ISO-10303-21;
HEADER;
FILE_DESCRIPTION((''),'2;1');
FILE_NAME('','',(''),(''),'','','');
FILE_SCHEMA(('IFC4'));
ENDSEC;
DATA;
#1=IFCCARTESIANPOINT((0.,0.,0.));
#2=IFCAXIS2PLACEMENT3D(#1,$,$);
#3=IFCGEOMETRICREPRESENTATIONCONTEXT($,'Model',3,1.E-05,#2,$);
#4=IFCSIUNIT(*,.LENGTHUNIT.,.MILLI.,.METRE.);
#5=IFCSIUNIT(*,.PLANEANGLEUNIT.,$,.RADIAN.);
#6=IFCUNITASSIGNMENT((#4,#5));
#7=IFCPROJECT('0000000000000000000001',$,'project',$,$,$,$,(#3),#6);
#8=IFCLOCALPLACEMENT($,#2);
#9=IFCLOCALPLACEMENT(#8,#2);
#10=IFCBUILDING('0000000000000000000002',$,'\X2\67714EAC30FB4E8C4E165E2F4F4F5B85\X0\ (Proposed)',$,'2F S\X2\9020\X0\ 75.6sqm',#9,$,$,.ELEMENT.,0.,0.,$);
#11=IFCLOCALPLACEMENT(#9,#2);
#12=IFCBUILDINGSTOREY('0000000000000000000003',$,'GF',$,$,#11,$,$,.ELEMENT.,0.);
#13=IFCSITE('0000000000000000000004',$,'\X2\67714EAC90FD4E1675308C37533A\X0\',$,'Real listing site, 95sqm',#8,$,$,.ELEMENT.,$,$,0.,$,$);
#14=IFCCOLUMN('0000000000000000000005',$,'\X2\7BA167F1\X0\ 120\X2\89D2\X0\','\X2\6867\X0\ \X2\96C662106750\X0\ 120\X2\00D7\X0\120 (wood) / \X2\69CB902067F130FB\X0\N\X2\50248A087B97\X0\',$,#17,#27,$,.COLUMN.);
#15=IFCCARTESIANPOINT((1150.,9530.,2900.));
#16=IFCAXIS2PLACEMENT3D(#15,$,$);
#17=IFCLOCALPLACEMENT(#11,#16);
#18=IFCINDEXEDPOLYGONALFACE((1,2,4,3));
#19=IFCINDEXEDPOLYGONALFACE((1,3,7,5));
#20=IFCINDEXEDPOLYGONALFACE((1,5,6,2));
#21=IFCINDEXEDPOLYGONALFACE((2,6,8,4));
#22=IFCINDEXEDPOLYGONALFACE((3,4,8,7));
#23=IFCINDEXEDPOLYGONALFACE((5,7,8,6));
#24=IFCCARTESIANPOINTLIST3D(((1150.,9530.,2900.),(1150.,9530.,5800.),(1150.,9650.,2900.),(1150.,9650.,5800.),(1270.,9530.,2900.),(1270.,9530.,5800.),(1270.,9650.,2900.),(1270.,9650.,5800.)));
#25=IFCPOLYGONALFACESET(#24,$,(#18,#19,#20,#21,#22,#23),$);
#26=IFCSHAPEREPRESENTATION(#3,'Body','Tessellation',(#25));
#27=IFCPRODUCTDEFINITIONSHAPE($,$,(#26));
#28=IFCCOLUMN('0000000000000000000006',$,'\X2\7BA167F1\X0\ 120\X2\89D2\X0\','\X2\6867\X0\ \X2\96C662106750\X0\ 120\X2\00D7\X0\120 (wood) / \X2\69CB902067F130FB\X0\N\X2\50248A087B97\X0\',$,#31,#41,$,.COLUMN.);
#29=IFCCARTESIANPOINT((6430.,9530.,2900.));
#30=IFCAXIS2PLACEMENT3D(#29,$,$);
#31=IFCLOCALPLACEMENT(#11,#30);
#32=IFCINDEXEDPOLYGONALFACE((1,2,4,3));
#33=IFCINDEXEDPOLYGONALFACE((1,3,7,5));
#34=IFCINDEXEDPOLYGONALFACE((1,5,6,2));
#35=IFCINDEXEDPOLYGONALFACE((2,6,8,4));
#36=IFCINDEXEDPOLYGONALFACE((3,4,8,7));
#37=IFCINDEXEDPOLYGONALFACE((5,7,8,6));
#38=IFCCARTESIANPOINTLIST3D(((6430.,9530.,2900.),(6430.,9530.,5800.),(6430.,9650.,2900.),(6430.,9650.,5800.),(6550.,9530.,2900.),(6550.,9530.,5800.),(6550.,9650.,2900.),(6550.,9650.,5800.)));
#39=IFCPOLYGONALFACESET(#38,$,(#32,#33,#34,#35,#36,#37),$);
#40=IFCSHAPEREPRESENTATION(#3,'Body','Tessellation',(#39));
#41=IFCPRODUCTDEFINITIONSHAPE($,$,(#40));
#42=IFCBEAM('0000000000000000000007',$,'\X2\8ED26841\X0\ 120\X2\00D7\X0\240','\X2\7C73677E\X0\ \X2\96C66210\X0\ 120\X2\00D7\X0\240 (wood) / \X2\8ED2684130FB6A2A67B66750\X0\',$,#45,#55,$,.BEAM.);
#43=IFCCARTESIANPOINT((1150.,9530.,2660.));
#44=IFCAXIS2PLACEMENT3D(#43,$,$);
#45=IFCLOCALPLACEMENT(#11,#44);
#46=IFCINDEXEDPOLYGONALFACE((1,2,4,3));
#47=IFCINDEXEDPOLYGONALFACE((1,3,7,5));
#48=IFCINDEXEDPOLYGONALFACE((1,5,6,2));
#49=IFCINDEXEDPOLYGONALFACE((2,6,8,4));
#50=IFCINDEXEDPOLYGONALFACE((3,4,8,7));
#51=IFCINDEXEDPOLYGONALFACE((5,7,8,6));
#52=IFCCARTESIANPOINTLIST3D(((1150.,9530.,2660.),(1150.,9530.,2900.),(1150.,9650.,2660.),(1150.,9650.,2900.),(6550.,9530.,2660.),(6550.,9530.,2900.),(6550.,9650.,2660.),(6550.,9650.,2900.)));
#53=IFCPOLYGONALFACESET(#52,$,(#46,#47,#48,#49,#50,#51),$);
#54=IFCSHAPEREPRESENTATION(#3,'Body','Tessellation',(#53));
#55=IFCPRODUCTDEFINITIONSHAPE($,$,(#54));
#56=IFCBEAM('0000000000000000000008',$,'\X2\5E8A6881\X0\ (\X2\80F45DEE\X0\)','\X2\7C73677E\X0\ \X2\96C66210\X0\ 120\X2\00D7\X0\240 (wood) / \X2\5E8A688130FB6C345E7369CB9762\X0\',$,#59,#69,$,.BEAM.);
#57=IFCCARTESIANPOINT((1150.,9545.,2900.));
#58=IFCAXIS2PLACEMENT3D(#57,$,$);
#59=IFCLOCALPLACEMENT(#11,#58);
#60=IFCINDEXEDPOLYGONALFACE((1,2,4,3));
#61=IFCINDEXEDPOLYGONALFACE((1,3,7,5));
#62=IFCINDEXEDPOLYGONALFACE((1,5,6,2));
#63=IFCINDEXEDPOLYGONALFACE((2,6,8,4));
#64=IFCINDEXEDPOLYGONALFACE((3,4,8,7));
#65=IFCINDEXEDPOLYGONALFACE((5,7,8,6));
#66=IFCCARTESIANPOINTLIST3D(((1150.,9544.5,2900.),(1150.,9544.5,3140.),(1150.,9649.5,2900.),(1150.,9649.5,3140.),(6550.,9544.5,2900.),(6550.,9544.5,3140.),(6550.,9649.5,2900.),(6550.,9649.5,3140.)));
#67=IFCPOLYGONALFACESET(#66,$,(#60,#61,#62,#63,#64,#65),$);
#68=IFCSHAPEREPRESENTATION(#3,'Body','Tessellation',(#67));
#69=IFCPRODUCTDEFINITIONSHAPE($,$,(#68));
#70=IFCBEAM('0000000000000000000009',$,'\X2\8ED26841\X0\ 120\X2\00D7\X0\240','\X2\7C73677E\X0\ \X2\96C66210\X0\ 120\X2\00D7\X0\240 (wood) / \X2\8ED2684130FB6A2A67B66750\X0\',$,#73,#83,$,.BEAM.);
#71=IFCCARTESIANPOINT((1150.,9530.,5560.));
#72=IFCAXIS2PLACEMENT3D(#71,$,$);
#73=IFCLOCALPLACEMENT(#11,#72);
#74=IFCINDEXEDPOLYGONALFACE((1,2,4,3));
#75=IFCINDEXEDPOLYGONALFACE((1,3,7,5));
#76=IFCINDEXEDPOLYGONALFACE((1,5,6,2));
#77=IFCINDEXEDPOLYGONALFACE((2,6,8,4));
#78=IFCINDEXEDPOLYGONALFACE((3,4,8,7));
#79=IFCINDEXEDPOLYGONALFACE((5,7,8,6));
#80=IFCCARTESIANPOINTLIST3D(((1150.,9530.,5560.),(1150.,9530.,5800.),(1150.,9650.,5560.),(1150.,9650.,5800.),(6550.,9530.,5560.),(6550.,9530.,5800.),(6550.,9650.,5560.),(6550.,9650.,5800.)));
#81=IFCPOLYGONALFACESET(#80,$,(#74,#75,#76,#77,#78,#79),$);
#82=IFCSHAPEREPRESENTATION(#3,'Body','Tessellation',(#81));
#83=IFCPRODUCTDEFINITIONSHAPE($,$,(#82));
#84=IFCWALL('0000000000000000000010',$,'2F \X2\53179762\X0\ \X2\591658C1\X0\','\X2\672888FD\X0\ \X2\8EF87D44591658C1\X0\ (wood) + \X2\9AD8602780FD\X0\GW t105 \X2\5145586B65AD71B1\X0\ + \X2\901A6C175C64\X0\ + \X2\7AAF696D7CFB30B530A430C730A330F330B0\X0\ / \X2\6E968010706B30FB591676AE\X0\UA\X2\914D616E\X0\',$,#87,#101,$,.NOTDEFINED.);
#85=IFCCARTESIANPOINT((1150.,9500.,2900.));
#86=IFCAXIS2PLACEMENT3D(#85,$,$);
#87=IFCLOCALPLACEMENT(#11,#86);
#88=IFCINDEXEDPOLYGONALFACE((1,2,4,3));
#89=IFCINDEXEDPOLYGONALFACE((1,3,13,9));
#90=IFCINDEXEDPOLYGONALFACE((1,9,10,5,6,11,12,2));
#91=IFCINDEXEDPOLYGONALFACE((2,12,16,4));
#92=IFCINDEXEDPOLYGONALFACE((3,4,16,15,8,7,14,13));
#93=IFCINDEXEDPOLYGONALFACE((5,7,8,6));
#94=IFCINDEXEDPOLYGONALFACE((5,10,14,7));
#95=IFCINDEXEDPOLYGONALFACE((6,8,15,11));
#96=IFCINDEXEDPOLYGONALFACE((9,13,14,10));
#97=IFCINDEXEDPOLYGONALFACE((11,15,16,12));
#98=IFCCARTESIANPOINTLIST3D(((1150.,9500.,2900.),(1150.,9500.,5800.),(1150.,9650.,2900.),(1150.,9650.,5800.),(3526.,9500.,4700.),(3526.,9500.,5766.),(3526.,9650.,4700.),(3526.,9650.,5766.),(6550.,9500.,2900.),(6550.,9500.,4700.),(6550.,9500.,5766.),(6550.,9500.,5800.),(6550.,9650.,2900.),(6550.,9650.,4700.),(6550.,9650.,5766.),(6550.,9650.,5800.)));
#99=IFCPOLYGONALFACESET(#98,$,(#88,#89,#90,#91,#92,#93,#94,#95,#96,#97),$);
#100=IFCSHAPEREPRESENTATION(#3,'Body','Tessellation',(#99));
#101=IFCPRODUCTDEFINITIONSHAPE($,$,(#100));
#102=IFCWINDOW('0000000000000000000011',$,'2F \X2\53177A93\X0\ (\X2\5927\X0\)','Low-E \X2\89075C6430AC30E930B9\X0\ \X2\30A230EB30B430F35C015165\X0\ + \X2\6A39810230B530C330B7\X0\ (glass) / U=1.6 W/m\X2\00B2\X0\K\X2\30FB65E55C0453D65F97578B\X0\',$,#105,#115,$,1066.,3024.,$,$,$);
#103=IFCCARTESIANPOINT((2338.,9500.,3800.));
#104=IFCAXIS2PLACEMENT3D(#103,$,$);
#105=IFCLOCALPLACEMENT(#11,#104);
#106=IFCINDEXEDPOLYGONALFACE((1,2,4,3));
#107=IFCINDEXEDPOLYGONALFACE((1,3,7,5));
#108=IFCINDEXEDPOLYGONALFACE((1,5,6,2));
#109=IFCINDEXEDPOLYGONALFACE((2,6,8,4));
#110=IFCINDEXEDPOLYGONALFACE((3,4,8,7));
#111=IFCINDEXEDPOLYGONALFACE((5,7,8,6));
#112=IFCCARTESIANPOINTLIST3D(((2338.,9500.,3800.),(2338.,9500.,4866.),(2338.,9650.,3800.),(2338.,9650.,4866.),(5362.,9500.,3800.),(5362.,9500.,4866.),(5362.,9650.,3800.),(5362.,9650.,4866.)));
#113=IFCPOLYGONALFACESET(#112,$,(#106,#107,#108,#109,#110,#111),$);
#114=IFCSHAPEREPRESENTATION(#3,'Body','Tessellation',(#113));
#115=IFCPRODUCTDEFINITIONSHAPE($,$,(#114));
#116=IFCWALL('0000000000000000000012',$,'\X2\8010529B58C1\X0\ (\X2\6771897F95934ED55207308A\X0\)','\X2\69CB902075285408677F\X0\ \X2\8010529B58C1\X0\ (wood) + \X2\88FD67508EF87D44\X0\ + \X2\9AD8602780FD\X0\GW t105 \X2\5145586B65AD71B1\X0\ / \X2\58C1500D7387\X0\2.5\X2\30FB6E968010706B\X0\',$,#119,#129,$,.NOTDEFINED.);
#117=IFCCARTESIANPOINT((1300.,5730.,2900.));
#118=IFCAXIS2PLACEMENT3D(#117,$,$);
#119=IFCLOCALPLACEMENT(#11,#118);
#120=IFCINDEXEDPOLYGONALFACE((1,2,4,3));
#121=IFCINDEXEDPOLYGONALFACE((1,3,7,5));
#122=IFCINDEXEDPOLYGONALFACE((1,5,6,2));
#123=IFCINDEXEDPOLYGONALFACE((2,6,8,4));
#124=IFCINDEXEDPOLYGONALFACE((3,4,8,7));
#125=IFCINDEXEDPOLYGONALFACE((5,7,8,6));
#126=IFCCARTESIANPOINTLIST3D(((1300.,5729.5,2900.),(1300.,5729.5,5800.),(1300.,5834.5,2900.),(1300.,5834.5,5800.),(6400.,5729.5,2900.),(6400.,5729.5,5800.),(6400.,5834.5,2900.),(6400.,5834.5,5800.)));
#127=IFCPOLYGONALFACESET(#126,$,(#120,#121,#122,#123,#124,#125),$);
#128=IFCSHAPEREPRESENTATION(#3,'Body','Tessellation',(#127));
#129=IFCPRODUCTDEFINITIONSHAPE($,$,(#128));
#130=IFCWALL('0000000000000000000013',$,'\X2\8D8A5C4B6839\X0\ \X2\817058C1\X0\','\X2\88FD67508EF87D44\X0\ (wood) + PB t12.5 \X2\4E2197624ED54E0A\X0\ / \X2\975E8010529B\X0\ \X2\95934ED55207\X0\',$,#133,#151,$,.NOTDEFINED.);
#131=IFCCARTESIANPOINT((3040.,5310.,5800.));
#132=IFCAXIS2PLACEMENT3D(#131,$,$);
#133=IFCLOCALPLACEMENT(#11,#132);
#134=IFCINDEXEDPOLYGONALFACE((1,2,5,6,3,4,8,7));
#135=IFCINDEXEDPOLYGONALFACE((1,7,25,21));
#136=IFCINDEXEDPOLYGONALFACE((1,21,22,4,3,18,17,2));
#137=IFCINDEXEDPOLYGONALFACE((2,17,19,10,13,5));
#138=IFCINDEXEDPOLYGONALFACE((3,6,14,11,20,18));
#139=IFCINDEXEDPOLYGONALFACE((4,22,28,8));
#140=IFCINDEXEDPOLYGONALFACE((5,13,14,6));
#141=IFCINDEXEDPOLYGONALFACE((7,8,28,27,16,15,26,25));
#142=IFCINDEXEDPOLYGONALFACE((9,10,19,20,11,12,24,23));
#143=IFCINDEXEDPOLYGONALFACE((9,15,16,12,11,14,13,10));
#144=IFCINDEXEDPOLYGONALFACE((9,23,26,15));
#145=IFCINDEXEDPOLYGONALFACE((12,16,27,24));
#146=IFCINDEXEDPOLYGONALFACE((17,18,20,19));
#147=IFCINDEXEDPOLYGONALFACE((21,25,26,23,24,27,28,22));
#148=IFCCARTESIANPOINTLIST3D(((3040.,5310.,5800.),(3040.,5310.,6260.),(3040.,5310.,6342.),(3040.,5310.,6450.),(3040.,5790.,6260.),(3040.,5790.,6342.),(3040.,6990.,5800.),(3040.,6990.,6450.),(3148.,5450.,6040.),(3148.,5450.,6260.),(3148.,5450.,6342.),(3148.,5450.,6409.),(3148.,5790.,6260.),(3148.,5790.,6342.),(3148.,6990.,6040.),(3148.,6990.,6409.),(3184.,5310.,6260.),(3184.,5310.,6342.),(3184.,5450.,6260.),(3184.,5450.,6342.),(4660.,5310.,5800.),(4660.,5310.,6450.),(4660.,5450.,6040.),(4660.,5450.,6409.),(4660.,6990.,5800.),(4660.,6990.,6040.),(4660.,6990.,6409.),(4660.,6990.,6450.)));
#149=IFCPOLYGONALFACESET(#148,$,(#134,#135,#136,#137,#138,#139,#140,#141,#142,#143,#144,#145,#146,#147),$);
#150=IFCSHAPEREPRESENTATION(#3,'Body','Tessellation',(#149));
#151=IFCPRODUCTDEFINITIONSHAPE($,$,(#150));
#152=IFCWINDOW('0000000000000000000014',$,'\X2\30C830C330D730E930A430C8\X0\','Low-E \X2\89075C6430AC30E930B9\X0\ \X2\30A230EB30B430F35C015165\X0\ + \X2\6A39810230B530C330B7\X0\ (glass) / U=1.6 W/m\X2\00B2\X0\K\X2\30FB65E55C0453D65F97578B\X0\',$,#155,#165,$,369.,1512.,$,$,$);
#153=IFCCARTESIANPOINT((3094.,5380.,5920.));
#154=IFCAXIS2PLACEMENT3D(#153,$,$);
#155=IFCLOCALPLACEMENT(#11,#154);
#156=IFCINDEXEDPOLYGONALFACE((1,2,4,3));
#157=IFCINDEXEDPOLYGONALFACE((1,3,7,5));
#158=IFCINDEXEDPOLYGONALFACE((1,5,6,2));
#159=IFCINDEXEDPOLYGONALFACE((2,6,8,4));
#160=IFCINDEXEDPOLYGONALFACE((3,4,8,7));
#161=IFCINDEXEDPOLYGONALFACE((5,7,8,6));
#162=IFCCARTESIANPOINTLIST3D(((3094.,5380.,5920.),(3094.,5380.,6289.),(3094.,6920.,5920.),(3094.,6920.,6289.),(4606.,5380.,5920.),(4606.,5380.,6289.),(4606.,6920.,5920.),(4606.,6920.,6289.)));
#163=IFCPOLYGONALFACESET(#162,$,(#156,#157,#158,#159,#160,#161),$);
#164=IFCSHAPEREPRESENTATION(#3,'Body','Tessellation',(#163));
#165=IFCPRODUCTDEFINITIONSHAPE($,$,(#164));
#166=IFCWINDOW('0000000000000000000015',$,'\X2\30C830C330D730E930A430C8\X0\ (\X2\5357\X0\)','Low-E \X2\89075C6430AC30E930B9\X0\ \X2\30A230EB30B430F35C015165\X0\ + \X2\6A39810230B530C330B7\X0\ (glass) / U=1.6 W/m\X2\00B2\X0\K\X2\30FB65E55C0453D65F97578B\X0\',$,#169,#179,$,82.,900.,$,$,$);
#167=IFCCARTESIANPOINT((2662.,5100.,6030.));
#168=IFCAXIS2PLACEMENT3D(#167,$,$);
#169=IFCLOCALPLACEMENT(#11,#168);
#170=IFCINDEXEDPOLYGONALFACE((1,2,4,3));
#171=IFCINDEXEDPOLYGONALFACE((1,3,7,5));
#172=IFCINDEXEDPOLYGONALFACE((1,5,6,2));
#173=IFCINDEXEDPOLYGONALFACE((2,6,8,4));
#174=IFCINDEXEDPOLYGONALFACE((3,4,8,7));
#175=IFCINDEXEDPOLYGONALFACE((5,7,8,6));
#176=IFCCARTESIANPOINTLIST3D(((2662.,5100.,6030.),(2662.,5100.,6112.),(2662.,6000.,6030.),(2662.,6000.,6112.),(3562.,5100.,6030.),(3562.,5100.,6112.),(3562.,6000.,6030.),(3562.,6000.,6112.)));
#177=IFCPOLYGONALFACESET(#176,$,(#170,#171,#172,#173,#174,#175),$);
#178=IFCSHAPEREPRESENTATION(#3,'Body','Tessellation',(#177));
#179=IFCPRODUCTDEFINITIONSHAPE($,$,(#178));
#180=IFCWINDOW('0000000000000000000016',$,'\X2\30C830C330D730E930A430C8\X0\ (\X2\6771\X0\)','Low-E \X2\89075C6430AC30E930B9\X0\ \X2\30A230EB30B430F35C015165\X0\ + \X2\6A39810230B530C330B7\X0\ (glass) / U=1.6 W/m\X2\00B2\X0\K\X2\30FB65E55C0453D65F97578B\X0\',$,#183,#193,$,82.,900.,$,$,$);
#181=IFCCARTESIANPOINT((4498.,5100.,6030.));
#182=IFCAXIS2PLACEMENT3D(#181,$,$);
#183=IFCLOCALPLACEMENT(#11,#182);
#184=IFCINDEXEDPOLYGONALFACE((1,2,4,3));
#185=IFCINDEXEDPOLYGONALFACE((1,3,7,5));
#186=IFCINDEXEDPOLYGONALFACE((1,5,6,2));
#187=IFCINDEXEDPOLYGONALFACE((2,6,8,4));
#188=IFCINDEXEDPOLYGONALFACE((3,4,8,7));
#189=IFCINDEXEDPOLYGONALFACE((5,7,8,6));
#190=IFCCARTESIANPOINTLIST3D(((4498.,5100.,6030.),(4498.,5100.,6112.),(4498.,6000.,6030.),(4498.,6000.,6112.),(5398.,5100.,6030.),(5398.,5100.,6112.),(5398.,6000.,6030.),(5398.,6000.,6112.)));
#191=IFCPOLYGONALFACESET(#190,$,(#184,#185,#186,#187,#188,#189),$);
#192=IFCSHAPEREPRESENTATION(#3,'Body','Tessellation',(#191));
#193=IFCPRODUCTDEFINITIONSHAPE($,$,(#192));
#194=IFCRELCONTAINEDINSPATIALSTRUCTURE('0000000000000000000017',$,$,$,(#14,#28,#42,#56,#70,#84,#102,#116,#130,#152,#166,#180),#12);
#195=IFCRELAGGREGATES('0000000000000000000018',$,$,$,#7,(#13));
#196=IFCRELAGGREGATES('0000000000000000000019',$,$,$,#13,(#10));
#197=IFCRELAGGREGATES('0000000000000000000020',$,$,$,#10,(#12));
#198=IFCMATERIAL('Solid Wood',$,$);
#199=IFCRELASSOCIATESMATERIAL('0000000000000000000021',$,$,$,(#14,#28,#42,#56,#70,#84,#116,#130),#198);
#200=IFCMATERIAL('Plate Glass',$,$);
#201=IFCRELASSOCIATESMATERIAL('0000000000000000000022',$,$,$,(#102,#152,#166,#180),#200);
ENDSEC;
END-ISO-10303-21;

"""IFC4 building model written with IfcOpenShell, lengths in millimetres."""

from ifc_helpers import new_model, si_unit, frame, frame_2d, origin, place, context, project, spatial, rectangle, extrude, material, element, fill, save


model = new_model("IFC4")

# Units and contexts
model_context = context("Model", 3, precision=1e-05, world=origin())
ifc_project = project(units=[si_unit("LENGTHUNIT", "METRE", prefix="MILLI"), si_unit("PLANEANGLEUNIT", "RADIAN")], contexts=[model_context])

# Site, building, storey
site_placement = place(None, origin())
site = spatial("IfcSite", under=ifc_project, at=site_placement, Name="東京都世田谷区", ObjectType="Real listing site, 95sqm", CompositionType="ELEMENT", RefElevation=0.0)
building_placement = place(site_placement, origin())
building = spatial("IfcBuilding", under=site, at=building_placement, Name="東京・二世帯住宅 (Proposed)", ObjectType="2F S造 75.6sqm", CompositionType="ELEMENT", ElevationOfRefHeight=0.0, ElevationOfTerrain=0.0)
storey_placement = place(building_placement, origin())
storey = spatial("IfcBuildingStorey", under=building, at=storey_placement, Name="GF", CompositionType="ELEMENT", Elevation=0.0)

# Columns
ifc_material_1 = material(Name="Solid Wood")
column_1_placement = place(storey_placement, frame((1150.0, 9530.0, 2900.0)))
element("IfcColumn", 1, at=column_1_placement, inside=storey, material=ifc_material_1, Name="管柱 120角", Description="桧 集成材 120×120 (wood) / 構造柱・N値計算", PredefinedType="COLUMN", context=model_context, shape_type="SweptSolid", body=[
    extrude(rectangle(XDim=120.0, YDim=120.0, at=frame_2d((60.0, 60.0))), frame((1150.0, 9530.0, 2900.0)), (0.0, 0.0, 1.0), 2900.0),
])
column_2_placement = place(storey_placement, frame((6430.0, 9530.0, 2900.0)))
element("IfcColumn", 2, at=column_2_placement, inside=storey, material=ifc_material_1, Name="管柱 120角", Description="桧 集成材 120×120 (wood) / 構造柱・N値計算", PredefinedType="COLUMN", context=model_context, shape_type="SweptSolid", body=[
    extrude(rectangle(XDim=120.0, YDim=120.0, at=frame_2d((60.0, 60.0))), frame((6430.0, 9530.0, 2900.0)), (0.0, 0.0, 1.0), 2900.0),
])

# Beams
beam_1_placement = place(storey_placement, frame((1150.0, 9530.0, 2660.0)))
element("IfcBeam", 3, at=beam_1_placement, inside=storey, material=ifc_material_1, Name="軒桁 120×240", Description="米松 集成 120×240 (wood) / 軒桁・横架材", PredefinedType="BEAM", context=model_context, shape_type="SweptSolid", body=[
    extrude(rectangle(XDim=5400.0, YDim=120.0, at=frame_2d((2700.0, 60.0))), frame((1150.0, 9530.0, 2660.0)), (0.0, 0.0, 1.0), 240.0),
])
beam_2_placement = place(storey_placement, frame((1150.0, 9545.0, 2900.0)))
element("IfcBeam", 4, at=beam_2_placement, inside=storey, material=ifc_material_1, Name="床梁 (胴差)", Description="米松 集成 120×240 (wood) / 床梁・水平構面", PredefinedType="BEAM", context=model_context, shape_type="SweptSolid", body=[
    extrude(rectangle(XDim=5400.0, YDim=105.0, at=frame_2d((2700.0, 52.0))), frame((1150.0, 9545.0, 2900.0)), (0.0, 0.0, 1.0), 240.0),
])
beam_3_placement = place(storey_placement, frame((1150.0, 9530.0, 5560.0)))
element("IfcBeam", 5, at=beam_3_placement, inside=storey, material=ifc_material_1, Name="軒桁 120×240", Description="米松 集成 120×240 (wood) / 軒桁・横架材", PredefinedType="BEAM", context=model_context, shape_type="SweptSolid", body=[
    extrude(rectangle(XDim=5400.0, YDim=120.0, at=frame_2d((2700.0, 60.0))), frame((1150.0, 9530.0, 5560.0)), (0.0, 0.0, 1.0), 240.0),
])

# Wall, opening, window
wall_1_placement = place(storey_placement, frame((1150.0, 9500.0, 2900.0)))
wall_1 = element("IfcWall", 6, at=wall_1_placement, inside=storey, material=ifc_material_1, Name="2F 北面 外壁", Description="木製 軸組外壁 (wood) + 高性能GW t105 充填断熱 + 通気層 + 窯業系サイディング / 準耐火・外皮UA配慮", PredefinedType="NOTDEFINED", context=model_context, shape_type="SweptSolid", body=[
    extrude(rectangle(XDim=5400.0, YDim=150.0, at=frame_2d((2700.0, 75.0))), frame((1150.0, 9500.0, 2900.0)), (0.0, 0.0, 1.0), 2900.0),
])
opening_1_placement = place(storey_placement, frame((2338.0, 9500.0, 3800.0)))
opening_1 = element("IfcOpeningElement", 7, at=opening_1_placement, cuts=wall_1, PredefinedType="NOTDEFINED", context=model_context, shape_type="SweptSolid", body=[
    extrude(rectangle(XDim=3024.0, YDim=150.0, at=frame_2d((1512.0, 75.0))), frame((2338.0, 9500.0, 3800.0)), (0.0, 0.0, 1.0), 1066.0),
])
ifc_material_2 = material(Name="Plate Glass")
window_1_placement = place(storey_placement, frame((2338.0, 9500.0, 3800.0)))
window_1 = element("IfcWindow", 8, at=window_1_placement, inside=storey, material=ifc_material_2, Name="2F 北窓 (大)", Description="Low-E 複層ガラス アルゴン封入 + 樹脂サッシ (glass) / U=1.6 W/m²K・日射取得型", OverallHeight=1066.0, OverallWidth=3024.0, context=model_context, shape_type="SweptSolid", body=[
    extrude(rectangle(XDim=3024.0, YDim=150.0, at=frame_2d((1512.0, 75.0))), frame((2338.0, 9500.0, 3800.0)), (0.0, 0.0, 1.0), 1066.0),
])
fill(opening_1, window_1)

# Wall
wall_2_placement = place(storey_placement, frame((1300.0, 5730.0, 2900.0)))
element("IfcWall", 9, at=wall_2_placement, inside=storey, material=ifc_material_1, Name="耐力壁 (東西間仕切り)", Description="構造用合板 耐力壁 (wood) + 製材軸組 + 高性能GW t105 充填断熱 / 壁倍率2.5・準耐火", PredefinedType="NOTDEFINED", context=model_context, shape_type="SweptSolid", body=[
    extrude(rectangle(XDim=5100.0, YDim=105.0, at=frame_2d((2550.0, 52.0))), frame((1300.0, 5730.0, 2900.0)), (0.0, 0.0, 1.0), 2900.0),
])

# Wall, openings, windows
wall_3_placement = place(storey_placement, frame((3040.0, 5310.0, 5800.0)))
wall_3 = element("IfcWall", 10, at=wall_3_placement, inside=storey, material=ifc_material_1, Name="越屋根 腰壁", Description="製材軸組 (wood) + PB t12.5 両面仕上 / 非耐力 間仕切", PredefinedType="NOTDEFINED", context=model_context, shape_type="SweptSolid", body=[
    extrude(rectangle(XDim=1620.0, YDim=1680.0, at=frame_2d((810.0, 840.0))), frame((3040.0, 5310.0, 5800.0)), (0.0, 0.0, 1.0), 650.0),
])
opening_2_placement = place(storey_placement, frame((3094.0, 5380.0, 5920.0)))
opening_2 = element("IfcOpeningElement", 11, at=opening_2_placement, cuts=wall_3, PredefinedType="NOTDEFINED", context=model_context, shape_type="SweptSolid", body=[
    extrude(rectangle(XDim=1512.0, YDim=1540.0, at=frame_2d((756.0, 770.0))), frame((3094.0, 5380.0, 5920.0)), (0.0, 0.0, 1.0), 369.0),
])
opening_3_placement = place(storey_placement, frame((2662.0, 5100.0, 6030.0)))
opening_3 = element("IfcOpeningElement", 12, at=opening_3_placement, cuts=wall_3, PredefinedType="NOTDEFINED", context=model_context, shape_type="SweptSolid", body=[
    extrude(rectangle(XDim=900.0, YDim=900.0, at=frame_2d((450.0, 450.0))), frame((2662.0, 5100.0, 6030.0)), (0.0, 0.0, 1.0), 82.0),
])
opening_4_placement = place(storey_placement, frame((4498.0, 5100.0, 6030.0)))
opening_4 = element("IfcOpeningElement", 13, at=opening_4_placement, cuts=wall_3, PredefinedType="NOTDEFINED", context=model_context, shape_type="SweptSolid", body=[
    extrude(rectangle(XDim=900.0, YDim=900.0, at=frame_2d((450.0, 450.0))), frame((4498.0, 5100.0, 6030.0)), (0.0, 0.0, 1.0), 82.0),
])
window_2_placement = place(storey_placement, frame((3094.0, 5380.0, 5920.0)))
window_2 = element("IfcWindow", 14, at=window_2_placement, inside=storey, material=ifc_material_2, Name="トップライト", Description="Low-E 複層ガラス アルゴン封入 + 樹脂サッシ (glass) / U=1.6 W/m²K・日射取得型", OverallHeight=369.0, OverallWidth=1512.0, context=model_context, shape_type="SweptSolid", body=[
    extrude(rectangle(XDim=1512.0, YDim=1540.0, at=frame_2d((756.0, 770.0))), frame((3094.0, 5380.0, 5920.0)), (0.0, 0.0, 1.0), 369.0),
])
fill(opening_2, window_2)
window_3_placement = place(storey_placement, frame((2662.0, 5100.0, 6030.0)))
window_3 = element("IfcWindow", 15, at=window_3_placement, inside=storey, material=ifc_material_2, Name="トップライト (南)", Description="Low-E 複層ガラス アルゴン封入 + 樹脂サッシ (glass) / U=1.6 W/m²K・日射取得型", OverallHeight=82.0, OverallWidth=900.0, context=model_context, shape_type="SweptSolid", body=[
    extrude(rectangle(XDim=900.0, YDim=900.0, at=frame_2d((450.0, 450.0))), frame((2662.0, 5100.0, 6030.0)), (0.0, 0.0, 1.0), 82.0),
])
fill(opening_3, window_3)
window_4_placement = place(storey_placement, frame((4498.0, 5100.0, 6030.0)))
window_4 = element("IfcWindow", 16, at=window_4_placement, inside=storey, material=ifc_material_2, Name="トップライト (東)", Description="Low-E 複層ガラス アルゴン封入 + 樹脂サッシ (glass) / U=1.6 W/m²K・日射取得型", OverallHeight=82.0, OverallWidth=900.0, context=model_context, shape_type="SweptSolid", body=[
    extrude(rectangle(XDim=900.0, YDim=900.0, at=frame_2d((450.0, 450.0))), frame((4498.0, 5100.0, 6030.0)), (0.0, 0.0, 1.0), 82.0),
])
fill(opening_4, window_4)

save(model, "model.ifc")
